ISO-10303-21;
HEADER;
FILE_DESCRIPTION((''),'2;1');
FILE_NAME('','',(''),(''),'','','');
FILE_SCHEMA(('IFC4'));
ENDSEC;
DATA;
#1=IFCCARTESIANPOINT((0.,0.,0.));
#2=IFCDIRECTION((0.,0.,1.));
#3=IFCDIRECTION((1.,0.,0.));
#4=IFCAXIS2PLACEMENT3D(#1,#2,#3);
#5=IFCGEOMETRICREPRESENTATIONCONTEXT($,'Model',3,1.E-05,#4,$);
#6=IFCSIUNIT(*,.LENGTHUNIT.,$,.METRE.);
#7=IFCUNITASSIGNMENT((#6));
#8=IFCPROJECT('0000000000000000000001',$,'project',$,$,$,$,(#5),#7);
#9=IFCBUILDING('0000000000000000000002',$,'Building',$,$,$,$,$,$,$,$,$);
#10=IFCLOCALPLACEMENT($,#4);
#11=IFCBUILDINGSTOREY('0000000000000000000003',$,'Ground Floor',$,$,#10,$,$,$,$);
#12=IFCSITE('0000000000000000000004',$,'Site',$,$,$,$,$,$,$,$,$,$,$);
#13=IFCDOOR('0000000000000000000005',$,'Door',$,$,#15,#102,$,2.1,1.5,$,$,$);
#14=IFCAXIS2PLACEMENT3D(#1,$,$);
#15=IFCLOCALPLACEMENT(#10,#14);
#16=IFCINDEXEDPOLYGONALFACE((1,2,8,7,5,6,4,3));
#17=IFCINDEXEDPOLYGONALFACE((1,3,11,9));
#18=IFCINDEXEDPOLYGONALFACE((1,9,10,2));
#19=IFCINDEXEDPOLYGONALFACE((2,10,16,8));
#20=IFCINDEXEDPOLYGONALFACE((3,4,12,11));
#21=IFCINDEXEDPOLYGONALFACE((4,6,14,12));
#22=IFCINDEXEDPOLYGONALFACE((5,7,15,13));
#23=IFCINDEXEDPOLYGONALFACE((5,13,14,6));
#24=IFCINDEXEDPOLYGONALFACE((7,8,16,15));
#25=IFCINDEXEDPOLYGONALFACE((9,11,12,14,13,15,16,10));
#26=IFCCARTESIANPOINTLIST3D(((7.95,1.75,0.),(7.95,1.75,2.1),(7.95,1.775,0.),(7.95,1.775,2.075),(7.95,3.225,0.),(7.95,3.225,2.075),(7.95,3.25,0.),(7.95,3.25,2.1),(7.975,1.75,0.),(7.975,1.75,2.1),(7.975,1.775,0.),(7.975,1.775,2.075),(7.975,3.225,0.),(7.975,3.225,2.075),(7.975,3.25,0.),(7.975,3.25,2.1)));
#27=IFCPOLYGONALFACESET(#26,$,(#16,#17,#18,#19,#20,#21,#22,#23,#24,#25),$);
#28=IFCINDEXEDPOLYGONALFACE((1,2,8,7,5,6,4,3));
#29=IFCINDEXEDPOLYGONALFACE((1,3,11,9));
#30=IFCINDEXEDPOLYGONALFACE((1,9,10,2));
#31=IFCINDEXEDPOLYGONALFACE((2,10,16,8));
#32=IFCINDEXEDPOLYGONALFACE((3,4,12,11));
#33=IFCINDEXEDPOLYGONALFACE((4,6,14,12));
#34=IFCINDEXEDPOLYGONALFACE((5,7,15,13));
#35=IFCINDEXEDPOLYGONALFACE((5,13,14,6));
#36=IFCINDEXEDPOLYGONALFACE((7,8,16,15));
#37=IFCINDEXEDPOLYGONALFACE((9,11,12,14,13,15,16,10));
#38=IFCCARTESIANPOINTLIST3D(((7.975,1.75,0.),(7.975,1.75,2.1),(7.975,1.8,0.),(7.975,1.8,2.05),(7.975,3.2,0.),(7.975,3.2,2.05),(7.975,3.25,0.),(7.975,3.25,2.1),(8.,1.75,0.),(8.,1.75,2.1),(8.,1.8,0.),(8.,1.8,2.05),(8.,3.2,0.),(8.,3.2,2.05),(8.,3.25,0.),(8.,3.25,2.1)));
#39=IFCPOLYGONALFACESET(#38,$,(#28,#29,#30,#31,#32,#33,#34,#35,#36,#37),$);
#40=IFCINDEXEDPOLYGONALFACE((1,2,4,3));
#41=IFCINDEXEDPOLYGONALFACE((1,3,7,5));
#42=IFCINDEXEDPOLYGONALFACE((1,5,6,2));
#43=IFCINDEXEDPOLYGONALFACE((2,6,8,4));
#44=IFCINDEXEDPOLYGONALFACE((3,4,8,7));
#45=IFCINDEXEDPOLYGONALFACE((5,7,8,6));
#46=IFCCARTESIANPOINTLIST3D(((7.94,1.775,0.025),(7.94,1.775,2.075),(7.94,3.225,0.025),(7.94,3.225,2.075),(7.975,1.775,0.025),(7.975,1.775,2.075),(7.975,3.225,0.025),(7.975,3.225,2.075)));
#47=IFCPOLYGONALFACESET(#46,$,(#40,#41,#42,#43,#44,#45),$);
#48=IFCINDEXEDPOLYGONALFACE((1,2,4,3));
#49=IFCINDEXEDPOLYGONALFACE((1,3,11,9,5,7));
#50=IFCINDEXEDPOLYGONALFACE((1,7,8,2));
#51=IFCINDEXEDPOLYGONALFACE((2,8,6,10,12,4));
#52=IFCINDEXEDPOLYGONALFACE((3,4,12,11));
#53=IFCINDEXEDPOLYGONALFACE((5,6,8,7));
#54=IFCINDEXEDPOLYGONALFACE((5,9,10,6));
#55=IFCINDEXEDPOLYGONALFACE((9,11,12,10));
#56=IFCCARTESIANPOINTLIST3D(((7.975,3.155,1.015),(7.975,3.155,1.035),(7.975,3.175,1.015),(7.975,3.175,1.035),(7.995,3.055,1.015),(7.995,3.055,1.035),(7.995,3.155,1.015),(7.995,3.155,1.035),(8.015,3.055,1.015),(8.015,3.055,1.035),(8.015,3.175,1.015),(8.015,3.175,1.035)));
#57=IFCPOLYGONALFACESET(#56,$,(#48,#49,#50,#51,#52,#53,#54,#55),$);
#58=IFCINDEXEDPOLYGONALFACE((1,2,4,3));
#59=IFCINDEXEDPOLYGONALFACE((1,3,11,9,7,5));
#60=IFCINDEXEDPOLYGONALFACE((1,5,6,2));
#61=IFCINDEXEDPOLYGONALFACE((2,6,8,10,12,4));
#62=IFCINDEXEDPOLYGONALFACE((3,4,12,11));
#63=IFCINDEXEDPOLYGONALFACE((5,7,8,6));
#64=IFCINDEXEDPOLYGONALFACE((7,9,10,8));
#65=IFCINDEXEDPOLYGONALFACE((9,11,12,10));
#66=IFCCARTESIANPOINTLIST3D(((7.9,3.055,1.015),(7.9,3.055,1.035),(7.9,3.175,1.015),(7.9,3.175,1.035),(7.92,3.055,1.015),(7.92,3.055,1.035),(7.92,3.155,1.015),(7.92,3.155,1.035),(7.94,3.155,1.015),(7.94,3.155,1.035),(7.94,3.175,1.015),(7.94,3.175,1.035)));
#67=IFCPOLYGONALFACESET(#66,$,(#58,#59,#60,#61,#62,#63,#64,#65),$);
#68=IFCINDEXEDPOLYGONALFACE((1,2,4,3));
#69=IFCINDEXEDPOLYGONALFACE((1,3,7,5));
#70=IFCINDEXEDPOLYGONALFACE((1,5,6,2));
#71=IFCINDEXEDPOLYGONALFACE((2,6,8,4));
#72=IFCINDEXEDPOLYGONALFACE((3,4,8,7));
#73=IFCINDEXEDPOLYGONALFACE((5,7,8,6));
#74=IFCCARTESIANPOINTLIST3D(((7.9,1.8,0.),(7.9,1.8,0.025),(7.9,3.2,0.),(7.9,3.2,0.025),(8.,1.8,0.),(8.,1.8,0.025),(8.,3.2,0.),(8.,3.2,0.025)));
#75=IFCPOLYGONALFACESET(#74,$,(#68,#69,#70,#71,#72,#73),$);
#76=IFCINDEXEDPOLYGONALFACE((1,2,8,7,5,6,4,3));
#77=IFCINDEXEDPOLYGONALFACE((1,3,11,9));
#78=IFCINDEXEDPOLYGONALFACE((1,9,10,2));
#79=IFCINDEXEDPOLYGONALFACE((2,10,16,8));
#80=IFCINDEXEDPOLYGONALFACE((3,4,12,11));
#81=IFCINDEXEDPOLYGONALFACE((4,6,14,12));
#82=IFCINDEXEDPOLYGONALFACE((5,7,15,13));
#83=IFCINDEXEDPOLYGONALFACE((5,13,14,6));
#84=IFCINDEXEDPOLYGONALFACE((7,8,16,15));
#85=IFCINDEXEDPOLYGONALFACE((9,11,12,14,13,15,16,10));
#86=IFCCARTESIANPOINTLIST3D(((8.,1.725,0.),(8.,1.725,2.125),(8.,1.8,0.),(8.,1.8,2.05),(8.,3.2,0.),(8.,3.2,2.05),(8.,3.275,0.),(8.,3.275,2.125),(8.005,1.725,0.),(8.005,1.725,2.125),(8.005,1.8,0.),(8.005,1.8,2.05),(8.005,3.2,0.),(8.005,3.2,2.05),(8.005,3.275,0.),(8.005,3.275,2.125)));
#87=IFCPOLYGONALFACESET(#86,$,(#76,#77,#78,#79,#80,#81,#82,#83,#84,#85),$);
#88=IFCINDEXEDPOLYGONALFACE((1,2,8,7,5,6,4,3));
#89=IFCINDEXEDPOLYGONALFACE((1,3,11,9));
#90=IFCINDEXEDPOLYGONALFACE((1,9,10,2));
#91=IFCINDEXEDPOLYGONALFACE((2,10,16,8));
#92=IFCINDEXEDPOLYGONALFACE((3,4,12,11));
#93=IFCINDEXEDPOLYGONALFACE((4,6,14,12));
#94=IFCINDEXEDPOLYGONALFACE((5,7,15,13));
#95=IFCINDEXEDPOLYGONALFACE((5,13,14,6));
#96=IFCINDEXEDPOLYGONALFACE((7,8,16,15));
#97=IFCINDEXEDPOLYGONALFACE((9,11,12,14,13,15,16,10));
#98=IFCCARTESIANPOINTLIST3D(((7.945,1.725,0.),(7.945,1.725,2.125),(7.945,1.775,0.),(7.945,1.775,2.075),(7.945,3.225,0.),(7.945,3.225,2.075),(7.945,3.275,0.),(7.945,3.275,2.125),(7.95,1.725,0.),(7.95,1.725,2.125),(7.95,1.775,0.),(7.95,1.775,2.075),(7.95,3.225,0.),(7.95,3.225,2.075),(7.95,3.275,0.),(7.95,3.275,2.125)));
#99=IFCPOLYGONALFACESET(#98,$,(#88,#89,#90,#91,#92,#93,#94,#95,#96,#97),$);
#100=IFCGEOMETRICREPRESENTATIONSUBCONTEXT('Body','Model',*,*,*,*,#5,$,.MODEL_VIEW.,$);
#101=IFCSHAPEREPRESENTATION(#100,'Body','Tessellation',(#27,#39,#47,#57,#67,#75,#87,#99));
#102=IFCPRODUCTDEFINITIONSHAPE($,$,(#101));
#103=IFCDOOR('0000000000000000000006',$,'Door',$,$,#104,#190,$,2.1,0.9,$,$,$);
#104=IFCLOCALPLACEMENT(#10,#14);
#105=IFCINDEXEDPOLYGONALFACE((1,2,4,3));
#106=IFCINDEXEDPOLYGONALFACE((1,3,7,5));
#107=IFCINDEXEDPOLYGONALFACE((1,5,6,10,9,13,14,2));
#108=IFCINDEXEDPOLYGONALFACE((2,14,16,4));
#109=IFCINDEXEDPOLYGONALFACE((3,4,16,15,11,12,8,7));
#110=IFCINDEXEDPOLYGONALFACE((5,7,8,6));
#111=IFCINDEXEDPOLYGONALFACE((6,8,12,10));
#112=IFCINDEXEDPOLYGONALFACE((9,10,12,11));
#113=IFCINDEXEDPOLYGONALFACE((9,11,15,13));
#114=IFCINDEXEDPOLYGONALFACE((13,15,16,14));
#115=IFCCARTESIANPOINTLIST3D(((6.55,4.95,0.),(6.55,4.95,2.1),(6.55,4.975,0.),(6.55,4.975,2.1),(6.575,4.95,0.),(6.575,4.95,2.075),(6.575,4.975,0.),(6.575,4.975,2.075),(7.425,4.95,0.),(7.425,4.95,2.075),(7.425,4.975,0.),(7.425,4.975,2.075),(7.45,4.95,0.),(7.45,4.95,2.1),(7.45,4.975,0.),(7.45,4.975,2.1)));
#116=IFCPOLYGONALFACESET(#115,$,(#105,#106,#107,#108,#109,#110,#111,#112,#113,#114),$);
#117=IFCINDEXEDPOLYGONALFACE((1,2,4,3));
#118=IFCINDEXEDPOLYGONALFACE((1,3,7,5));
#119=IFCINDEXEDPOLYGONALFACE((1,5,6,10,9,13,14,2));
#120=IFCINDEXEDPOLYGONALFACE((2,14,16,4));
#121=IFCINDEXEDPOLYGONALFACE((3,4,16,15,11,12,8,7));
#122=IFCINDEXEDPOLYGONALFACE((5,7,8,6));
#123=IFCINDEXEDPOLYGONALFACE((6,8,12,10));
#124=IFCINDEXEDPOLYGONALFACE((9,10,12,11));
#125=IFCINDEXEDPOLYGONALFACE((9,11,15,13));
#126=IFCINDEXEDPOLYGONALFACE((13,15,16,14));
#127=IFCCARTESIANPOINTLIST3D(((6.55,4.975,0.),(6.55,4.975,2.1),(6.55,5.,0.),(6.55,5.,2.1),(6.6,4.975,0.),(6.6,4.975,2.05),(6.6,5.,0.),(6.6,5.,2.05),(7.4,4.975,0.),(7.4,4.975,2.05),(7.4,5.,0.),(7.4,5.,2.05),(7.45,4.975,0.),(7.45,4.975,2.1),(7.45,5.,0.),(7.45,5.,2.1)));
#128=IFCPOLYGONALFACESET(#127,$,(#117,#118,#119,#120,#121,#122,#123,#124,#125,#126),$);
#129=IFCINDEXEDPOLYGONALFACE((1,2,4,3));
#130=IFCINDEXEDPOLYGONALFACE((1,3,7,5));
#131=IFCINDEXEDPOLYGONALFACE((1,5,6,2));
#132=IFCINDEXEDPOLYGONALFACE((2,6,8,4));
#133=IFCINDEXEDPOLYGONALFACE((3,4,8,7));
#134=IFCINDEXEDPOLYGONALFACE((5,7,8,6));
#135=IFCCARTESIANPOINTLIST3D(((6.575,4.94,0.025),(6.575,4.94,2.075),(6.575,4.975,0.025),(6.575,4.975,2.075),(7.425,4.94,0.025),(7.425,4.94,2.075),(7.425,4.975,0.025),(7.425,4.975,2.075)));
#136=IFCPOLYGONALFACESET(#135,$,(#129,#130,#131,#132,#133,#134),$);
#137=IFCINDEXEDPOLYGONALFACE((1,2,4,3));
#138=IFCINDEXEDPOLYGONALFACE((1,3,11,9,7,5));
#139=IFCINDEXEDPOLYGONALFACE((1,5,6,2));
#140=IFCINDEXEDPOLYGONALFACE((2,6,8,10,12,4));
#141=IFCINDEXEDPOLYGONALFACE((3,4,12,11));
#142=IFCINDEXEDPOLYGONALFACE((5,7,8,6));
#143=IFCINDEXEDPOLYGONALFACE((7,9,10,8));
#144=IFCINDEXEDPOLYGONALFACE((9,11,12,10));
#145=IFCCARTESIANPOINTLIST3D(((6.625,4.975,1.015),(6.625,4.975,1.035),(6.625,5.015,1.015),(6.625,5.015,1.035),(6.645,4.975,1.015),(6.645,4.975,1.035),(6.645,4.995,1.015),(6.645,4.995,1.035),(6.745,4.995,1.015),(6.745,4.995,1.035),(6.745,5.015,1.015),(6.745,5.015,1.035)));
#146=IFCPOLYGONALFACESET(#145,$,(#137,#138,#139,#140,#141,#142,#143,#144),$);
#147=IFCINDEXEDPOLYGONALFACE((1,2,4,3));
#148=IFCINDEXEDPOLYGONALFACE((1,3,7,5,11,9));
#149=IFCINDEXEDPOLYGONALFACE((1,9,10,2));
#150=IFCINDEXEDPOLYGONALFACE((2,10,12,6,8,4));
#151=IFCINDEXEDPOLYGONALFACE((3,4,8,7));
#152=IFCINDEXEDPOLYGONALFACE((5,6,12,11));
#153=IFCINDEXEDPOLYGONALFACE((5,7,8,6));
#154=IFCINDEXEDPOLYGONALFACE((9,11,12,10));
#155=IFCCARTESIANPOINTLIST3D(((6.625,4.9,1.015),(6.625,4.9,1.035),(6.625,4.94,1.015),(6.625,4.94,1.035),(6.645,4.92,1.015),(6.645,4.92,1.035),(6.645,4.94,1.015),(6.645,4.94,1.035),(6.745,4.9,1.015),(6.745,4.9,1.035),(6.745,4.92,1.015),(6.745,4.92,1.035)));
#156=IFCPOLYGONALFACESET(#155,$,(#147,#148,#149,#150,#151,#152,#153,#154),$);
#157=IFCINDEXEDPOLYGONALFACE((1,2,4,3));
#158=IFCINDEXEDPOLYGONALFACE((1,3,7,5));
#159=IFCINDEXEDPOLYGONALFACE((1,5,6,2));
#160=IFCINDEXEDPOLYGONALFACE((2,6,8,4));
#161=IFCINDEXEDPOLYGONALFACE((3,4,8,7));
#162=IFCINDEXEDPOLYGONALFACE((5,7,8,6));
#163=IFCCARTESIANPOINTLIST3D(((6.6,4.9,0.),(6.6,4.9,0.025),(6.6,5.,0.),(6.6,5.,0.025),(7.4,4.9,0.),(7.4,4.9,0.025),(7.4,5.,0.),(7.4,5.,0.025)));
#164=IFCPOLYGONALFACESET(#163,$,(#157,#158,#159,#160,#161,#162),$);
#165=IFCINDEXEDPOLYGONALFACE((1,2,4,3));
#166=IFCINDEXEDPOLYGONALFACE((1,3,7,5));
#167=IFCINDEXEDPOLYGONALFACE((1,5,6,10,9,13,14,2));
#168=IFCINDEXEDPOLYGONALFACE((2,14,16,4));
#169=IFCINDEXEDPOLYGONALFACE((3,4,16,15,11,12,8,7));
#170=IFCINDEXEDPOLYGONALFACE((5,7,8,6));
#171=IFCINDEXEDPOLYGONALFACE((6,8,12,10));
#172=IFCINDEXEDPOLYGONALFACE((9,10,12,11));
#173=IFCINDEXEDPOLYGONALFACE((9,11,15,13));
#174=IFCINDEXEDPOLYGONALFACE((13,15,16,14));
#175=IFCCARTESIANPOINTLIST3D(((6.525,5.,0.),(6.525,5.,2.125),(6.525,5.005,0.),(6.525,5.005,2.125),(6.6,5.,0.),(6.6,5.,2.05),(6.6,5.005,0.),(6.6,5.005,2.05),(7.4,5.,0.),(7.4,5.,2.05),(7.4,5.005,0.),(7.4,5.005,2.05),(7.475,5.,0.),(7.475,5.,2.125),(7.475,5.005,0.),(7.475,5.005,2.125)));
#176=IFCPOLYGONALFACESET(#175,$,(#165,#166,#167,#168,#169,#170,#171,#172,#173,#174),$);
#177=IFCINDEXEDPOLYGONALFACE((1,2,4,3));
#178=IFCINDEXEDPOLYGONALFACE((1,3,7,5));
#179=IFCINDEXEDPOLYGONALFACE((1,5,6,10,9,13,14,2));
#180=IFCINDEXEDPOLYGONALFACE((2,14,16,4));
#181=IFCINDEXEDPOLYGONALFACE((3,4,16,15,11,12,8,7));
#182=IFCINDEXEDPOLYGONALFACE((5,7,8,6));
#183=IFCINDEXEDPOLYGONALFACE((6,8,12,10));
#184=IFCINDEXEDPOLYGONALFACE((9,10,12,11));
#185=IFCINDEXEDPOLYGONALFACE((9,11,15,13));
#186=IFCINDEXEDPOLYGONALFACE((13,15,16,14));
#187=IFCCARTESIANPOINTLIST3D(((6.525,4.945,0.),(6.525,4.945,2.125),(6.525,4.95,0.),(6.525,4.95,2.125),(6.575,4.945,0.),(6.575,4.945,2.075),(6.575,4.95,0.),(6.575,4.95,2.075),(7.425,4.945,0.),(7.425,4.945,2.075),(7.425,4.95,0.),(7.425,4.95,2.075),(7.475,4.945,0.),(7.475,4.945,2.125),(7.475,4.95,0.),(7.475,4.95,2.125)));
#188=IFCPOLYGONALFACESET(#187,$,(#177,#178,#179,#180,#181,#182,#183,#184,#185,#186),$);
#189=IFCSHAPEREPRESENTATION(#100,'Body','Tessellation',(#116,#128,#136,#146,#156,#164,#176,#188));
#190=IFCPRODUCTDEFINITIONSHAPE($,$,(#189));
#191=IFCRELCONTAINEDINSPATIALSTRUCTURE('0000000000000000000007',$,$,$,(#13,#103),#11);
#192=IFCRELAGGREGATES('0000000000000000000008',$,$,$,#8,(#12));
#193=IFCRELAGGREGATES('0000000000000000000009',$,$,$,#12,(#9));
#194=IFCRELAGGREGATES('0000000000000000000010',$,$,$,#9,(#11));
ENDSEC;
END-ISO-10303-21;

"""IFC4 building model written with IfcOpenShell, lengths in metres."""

from ifc_helpers import new_model, si_unit, frame, origin_with_axes, place, context, subcontext, project, spatial, line, indexed_curve, outline, extrude, element, save


model = new_model("IFC4")

# Units and contexts
model_context = context("Model", 3, precision=1e-05, world=origin_with_axes())
body_context = subcontext(model_context, "Body", "Model", "MODEL_VIEW")
ifc_project = project(units=[si_unit("LENGTHUNIT", "METRE")], contexts=[model_context])

# Site, building, storey
site = spatial("IfcSite", under=ifc_project, Name="Site")
building = spatial("IfcBuilding", under=site, Name="Building")
storey_placement = place(None, origin_with_axes())
storey = spatial("IfcBuildingStorey", under=building, at=storey_placement, Name="Ground Floor")

# Doors
door_1_placement = place(storey_placement, frame((8.0, 1.75, 0.0), z_axis=(0.0, 0.0, 1.0), x_axis=(0.0, 1.0, 0.0)))
element("IfcDoor", 1, at=door_1_placement, inside=storey, Name="Door", OverallHeight=2.1, OverallWidth=1.5, context=body_context, shape_type="SweptSolid", body=[
    extrude(outline(indexed_curve([(0.0, 0.0), (0.0, 2.1), (1.5, 2.1), (1.5, 0.0), (1.475, 0.0), (1.475, 2.075), (0.025, 2.075), (0.025, 0.0)], segments=[line(1, 2, 3, 4, 5, 6, 7, 8, 1)])), frame((0.0, 0.025, 0.0), z_axis=(0.0, -1.0, 0.0), x_axis=(1.0, 0.0, 0.0)), (0.0, 0.0, -1.0), 0.025),
    extrude(outline(indexed_curve([(0.0, 0.0), (0.0, 2.1), (1.5, 2.1), (1.5, 0.0), (1.45, 0.0), (1.45, 2.05), (0.05, 2.05), (0.05, 0.0)], segments=[line(1, 2, 3, 4, 5, 6, 7, 8, 1)])), frame((0.0, 0.0, 0.0), z_axis=(0.0, -1.0, 0.0), x_axis=(1.0, 0.0, 0.0)), (0.0, 0.0, -1.0), 0.025),
    extrude(outline(indexed_curve([(0.0, 0.0), (1.45, 0.0), (1.45, 0.035), (0.0, 0.035)], segments=[line(1, 2, 3, 4, 1)])), frame((0.025, 0.025, 0.025), z_axis=(0.0, 0.0, 1.0), x_axis=(1.0, 0.0, 0.0)), (0.0, 0.0, 1.0), 2.05),
    extrude(outline(indexed_curve([(0.0, 0.0), (0.0, -0.04), (-0.12, -0.04), (-0.12, -0.02), (-0.02, -0.02), (-0.02, 0.0)], segments=[line(1, 2, 3, 4, 5, 6, 1)])), frame((1.425, 0.025, 1.015), z_axis=(0.0, 0.0, 1.0), x_axis=(1.0, 0.0, 0.0)), (0.0, 0.0, 1.0), 0.02),
    extrude(outline(indexed_curve([(0.0, 0.0), (0.0, 0.04), (-0.12, 0.04), (-0.12, 0.02), (-0.02, 0.02), (-0.02, 0.0)], segments=[line(1, 2, 3, 4, 5, 6, 1)])), frame((1.425, 0.06, 1.015), z_axis=(0.0, 0.0, 1.0), x_axis=(1.0, 0.0, 0.0)), (0.0, 0.0, 1.0), 0.02),
    extrude(outline(indexed_curve([(0.0, 0.0), (1.4, 0.0), (1.4, 0.1), (0.0, 0.1)], segments=[line(1, 2, 3, 4, 1)])), frame((0.05, 0.0, 0.0), z_axis=(0.0, 0.0, 1.0), x_axis=(1.0, 0.0, 0.0)), (0.0, 0.0, 1.0), 0.025),
    extrude(outline(indexed_curve([(0.0, 0.0), (0.0, 2.125), (1.55, 2.125), (1.55, 0.0), (1.475, 0.0), (1.475, 2.05), (0.075, 2.05), (0.075, 0.0)], segments=[line(1, 2, 3, 4, 5, 6, 7, 8, 1)])), frame((-0.025, -0.005, 0.0), z_axis=(0.0, -1.0, 0.0), x_axis=(1.0, 0.0, 0.0)), (0.0, 0.0, -1.0), 0.005),
    extrude(outline(indexed_curve([(0.0, 0.0), (0.0, 2.125), (1.55, 2.125), (1.55, 0.0), (1.5, 0.0), (1.5, 2.075), (0.05, 2.075), (0.05, 0.0)], segments=[line(1, 2, 3, 4, 5, 6, 7, 8, 1)])), frame((-0.025, 0.05, 0.0), z_axis=(0.0, -1.0, 0.0), x_axis=(1.0, 0.0, 0.0)), (0.0, 0.0, -1.0), 0.005),
])
door_2_placement = place(storey_placement, frame((7.45, 5.0, 0.0), z_axis=(0.0, 0.0, 1.0), x_axis=(-1.0, 0.0, 0.0)))
element("IfcDoor", 2, at=door_2_placement, inside=storey, Name="Door", OverallHeight=2.1, OverallWidth=0.9, context=body_context, shape_type="SweptSolid", body=[
    extrude(outline(indexed_curve([(0.0, 0.0), (0.0, 2.1), (0.9, 2.1), (0.9, 0.0), (0.875, 0.0), (0.875, 2.075), (0.025, 2.075), (0.025, 0.0)], segments=[line(1, 2, 3, 4, 5, 6, 7, 8, 1)])), frame((0.0, 0.025, 0.0), z_axis=(0.0, -1.0, 0.0), x_axis=(1.0, 0.0, 0.0)), (0.0, 0.0, -1.0), 0.025),
    extrude(outline(indexed_curve([(0.0, 0.0), (0.0, 2.1), (0.9, 2.1), (0.9, 0.0), (0.85, 0.0), (0.85, 2.05), (0.05, 2.05), (0.05, 0.0)], segments=[line(1, 2, 3, 4, 5, 6, 7, 8, 1)])), frame((0.0, 0.0, 0.0), z_axis=(0.0, -1.0, 0.0), x_axis=(1.0, 0.0, 0.0)), (0.0, 0.0, -1.0), 0.025),
    extrude(outline(indexed_curve([(0.0, 0.0), (0.85, 0.0), (0.85, 0.035), (0.0, 0.035)], segments=[line(1, 2, 3, 4, 1)])), frame((0.025, 0.025, 0.025), z_axis=(0.0, 0.0, 1.0), x_axis=(1.0, 0.0, 0.0)), (0.0, 0.0, 1.0), 2.05),
    extrude(outline(indexed_curve([(0.0, 0.0), (0.0, -0.04), (-0.12, -0.04), (-0.12, -0.02), (-0.02, -0.02), (-0.02, 0.0)], segments=[line(1, 2, 3, 4, 5, 6, 1)])), frame((0.825, 0.025, 1.015), z_axis=(0.0, 0.0, 1.0), x_axis=(1.0, 0.0, 0.0)), (0.0, 0.0, 1.0), 0.02),
    extrude(outline(indexed_curve([(0.0, 0.0), (0.0, 0.04), (-0.12, 0.04), (-0.12, 0.02), (-0.02, 0.02), (-0.02, 0.0)], segments=[line(1, 2, 3, 4, 5, 6, 1)])), frame((0.825, 0.06, 1.015), z_axis=(0.0, 0.0, 1.0), x_axis=(1.0, 0.0, 0.0)), (0.0, 0.0, 1.0), 0.02),
    extrude(outline(indexed_curve([(0.0, 0.0), (0.8, 0.0), (0.8, 0.1), (0.0, 0.1)], segments=[line(1, 2, 3, 4, 1)])), frame((0.05, 0.0, 0.0), z_axis=(0.0, 0.0, 1.0), x_axis=(1.0, 0.0, 0.0)), (0.0, 0.0, 1.0), 0.025),
    extrude(outline(indexed_curve([(0.0, 0.0), (0.0, 2.125), (0.95, 2.125), (0.95, 0.0), (0.875, 0.0), (0.875, 2.05), (0.075, 2.05), (0.075, 0.0)], segments=[line(1, 2, 3, 4, 5, 6, 7, 8, 1)])), frame((-0.025, -0.005, 0.0), z_axis=(0.0, -1.0, 0.0), x_axis=(1.0, 0.0, 0.0)), (0.0, 0.0, -1.0), 0.005),
    extrude(outline(indexed_curve([(0.0, 0.0), (0.0, 2.125), (0.95, 2.125), (0.95, 0.0), (0.9, 0.0), (0.9, 2.075), (0.05, 2.075), (0.05, 0.0)], segments=[line(1, 2, 3, 4, 5, 6, 7, 8, 1)])), frame((-0.025, 0.05, 0.0), z_axis=(0.0, -1.0, 0.0), x_axis=(1.0, 0.0, 0.0)), (0.0, 0.0, -1.0), 0.005),
])

save(model, "model.ifc")
